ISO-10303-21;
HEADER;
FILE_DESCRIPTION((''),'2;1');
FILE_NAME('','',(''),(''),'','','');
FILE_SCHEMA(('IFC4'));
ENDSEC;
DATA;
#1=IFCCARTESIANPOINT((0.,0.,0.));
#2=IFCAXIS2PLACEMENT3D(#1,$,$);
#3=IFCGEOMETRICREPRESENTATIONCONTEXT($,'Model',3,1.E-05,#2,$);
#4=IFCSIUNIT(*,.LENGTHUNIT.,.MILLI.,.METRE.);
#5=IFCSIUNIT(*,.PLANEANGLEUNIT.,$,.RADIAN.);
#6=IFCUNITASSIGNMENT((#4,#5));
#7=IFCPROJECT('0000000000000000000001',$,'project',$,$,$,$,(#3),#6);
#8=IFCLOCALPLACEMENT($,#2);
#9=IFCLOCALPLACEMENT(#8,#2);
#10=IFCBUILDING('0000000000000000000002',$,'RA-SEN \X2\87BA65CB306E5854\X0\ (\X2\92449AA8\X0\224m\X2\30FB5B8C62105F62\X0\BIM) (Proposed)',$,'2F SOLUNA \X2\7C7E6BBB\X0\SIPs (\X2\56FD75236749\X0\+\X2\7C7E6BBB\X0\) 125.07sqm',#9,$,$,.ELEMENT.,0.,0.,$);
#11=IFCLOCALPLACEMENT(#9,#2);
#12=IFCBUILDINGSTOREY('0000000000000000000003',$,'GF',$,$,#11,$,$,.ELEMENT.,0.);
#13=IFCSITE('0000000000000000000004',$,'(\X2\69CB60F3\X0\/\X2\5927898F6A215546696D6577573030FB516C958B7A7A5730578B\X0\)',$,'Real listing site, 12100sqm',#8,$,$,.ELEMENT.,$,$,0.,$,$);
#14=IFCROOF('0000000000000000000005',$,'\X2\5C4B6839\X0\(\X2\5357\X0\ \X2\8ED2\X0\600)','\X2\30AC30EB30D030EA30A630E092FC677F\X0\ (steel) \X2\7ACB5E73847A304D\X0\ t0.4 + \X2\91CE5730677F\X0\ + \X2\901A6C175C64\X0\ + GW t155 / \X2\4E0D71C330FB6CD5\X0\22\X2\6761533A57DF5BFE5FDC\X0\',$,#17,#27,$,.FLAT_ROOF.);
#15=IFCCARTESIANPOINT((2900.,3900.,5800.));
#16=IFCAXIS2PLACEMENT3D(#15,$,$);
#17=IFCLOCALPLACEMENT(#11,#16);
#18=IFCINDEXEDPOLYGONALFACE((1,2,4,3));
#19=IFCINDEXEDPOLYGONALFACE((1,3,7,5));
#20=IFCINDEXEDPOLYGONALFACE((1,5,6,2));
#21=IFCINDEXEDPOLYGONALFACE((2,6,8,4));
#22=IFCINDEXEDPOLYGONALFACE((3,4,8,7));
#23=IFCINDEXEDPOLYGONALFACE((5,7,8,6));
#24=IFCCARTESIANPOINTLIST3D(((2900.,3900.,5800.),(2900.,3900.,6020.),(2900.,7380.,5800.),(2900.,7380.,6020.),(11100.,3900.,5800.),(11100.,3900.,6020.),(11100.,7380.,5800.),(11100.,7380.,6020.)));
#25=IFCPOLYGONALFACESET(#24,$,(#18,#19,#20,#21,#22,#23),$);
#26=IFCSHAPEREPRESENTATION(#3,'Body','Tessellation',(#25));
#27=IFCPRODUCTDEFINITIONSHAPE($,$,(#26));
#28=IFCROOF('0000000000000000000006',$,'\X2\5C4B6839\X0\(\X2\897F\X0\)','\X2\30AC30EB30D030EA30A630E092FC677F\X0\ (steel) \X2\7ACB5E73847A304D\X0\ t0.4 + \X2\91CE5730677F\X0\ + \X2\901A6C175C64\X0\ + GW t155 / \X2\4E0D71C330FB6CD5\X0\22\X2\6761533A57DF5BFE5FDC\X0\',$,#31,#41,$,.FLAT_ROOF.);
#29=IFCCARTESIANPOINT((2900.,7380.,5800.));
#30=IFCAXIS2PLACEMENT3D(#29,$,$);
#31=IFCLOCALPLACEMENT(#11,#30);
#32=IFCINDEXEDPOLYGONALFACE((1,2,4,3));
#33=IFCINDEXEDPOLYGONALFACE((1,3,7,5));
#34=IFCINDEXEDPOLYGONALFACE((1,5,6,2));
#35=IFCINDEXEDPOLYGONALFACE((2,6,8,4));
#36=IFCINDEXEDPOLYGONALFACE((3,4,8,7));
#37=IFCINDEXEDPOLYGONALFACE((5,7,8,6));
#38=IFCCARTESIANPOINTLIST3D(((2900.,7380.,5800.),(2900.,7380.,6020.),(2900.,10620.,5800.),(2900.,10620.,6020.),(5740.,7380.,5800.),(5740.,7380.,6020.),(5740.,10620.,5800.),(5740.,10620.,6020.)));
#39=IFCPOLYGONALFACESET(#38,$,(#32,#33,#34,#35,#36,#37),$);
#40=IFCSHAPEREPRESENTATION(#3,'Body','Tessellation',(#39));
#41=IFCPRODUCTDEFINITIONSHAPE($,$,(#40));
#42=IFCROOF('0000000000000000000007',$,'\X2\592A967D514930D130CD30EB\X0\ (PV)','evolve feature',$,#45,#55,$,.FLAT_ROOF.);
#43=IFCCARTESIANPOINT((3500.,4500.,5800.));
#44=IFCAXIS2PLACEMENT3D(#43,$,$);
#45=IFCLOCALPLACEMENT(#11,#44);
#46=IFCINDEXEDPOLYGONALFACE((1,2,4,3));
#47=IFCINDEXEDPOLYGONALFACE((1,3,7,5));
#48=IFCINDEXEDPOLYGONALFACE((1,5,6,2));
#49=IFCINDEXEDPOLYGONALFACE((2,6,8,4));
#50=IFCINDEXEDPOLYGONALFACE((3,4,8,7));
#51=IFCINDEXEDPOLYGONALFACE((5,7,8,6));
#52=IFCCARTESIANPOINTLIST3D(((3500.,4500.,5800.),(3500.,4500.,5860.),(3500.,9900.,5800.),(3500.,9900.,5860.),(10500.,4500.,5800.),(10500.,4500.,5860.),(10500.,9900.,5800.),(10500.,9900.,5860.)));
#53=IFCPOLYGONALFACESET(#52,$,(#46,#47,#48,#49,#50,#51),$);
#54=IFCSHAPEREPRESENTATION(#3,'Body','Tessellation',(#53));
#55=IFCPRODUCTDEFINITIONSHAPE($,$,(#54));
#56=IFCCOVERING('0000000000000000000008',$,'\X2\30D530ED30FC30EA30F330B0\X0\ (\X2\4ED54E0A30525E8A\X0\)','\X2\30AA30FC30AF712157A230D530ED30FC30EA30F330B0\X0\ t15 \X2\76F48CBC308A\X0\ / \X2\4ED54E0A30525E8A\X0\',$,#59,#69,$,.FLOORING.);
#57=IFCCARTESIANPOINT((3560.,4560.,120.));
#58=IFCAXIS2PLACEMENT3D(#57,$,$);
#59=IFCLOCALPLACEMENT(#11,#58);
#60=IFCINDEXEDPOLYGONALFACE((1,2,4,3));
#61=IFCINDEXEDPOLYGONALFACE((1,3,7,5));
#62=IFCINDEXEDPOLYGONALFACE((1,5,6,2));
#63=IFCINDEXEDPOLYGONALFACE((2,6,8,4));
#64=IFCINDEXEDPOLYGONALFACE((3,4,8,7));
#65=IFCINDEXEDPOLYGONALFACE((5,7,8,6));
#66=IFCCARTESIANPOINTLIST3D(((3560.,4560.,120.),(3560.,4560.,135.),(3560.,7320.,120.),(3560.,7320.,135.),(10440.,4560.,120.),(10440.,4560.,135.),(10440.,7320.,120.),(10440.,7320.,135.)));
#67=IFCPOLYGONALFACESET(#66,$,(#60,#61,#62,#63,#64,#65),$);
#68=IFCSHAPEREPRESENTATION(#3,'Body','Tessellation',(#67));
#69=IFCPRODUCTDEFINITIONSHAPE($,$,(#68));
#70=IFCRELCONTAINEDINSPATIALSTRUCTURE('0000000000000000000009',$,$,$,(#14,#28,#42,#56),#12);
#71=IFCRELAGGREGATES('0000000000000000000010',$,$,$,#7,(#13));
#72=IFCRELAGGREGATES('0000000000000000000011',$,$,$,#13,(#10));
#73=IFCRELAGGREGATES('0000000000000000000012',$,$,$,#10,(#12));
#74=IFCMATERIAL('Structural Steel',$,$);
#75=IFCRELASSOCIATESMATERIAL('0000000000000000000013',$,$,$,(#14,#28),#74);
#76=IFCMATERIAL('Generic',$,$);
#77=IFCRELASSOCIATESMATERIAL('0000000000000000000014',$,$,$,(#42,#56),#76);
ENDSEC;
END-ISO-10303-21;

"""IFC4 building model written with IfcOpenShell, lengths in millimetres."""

from ifc_helpers import new_model, si_unit, frame, frame_2d, origin, place, context, project, spatial, rectangle, extrude, material, element, save


model = new_model("IFC4")

# Units and contexts
model_context = context("Model", 3, precision=1e-05, world=origin())
ifc_project = project(units=[si_unit("LENGTHUNIT", "METRE", prefix="MILLI"), si_unit("PLANEANGLEUNIT", "RADIAN")], contexts=[model_context])

# Site, building, storey
site_placement = place(None, origin())
site = spatial("IfcSite", under=ifc_project, at=site_placement, Name="(構想/大規模商業敷地・公開空地型)", ObjectType="Real listing site, 12100sqm", CompositionType="ELEMENT", RefElevation=0.0)
building_placement = place(site_placement, origin())
building = spatial("IfcBuilding", under=site, at=building_placement, Name="RA-SEN 螺旋の塔 (鉄骨224m・完成形BIM) (Proposed)", ObjectType="2F SOLUNA 籾殻SIPs (国産杉+籾殻) 125.07sqm", CompositionType="ELEMENT", ElevationOfRefHeight=0.0, ElevationOfTerrain=0.0)
storey_placement = place(building_placement, origin())
storey = spatial("IfcBuildingStorey", under=building, at=storey_placement, Name="GF", CompositionType="ELEMENT", Elevation=0.0)

# Shared definitions
ifc_material_1 = material(Name="Generic")

# Roofs
ifc_material_2 = material(Name="Structural Steel")
roof_1_placement = place(storey_placement, frame((2900.0, 3900.0, 5800.0)))
element("IfcRoof", 1, at=roof_1_placement, inside=storey, material=ifc_material_2, Name="屋根(南 軒600)", Description="ガルバリウム鋼板 (steel) 立平葺き t0.4 + 野地板 + 通気層 + GW t155 / 不燃・法22条区域対応", PredefinedType="FLAT_ROOF", context=model_context, shape_type="SweptSolid", body=[
    extrude(rectangle(XDim=8200.0, YDim=3480.0, at=frame_2d((4100.0, 1740.0))), frame((2900.0, 3900.0, 5800.0)), (0.0, 0.0, 1.0), 220.0),
])
roof_2_placement = place(storey_placement, frame((2900.0, 7380.0, 5800.0)))
element("IfcRoof", 2, at=roof_2_placement, inside=storey, material=ifc_material_2, Name="屋根(西)", Description="ガルバリウム鋼板 (steel) 立平葺き t0.4 + 野地板 + 通気層 + GW t155 / 不燃・法22条区域対応", PredefinedType="FLAT_ROOF", context=model_context, shape_type="SweptSolid", body=[
    extrude(rectangle(XDim=2840.0, YDim=3240.0, at=frame_2d((1420.0, 1620.0))), frame((2900.0, 7380.0, 5800.0)), (0.0, 0.0, 1.0), 220.0),
])
roof_3_placement = place(storey_placement, frame((3500.0, 4500.0, 5800.0)))
element("IfcRoof", 3, at=roof_3_placement, inside=storey, material=ifc_material_1, Name="太陽光パネル (PV)", Description="evolve feature", PredefinedType="FLAT_ROOF", context=model_context, shape_type="SweptSolid", body=[
    extrude(rectangle(XDim=7000.0, YDim=5400.0, at=frame_2d((3500.0, 2700.0))), frame((3500.0, 4500.0, 5800.0)), (0.0, 0.0, 1.0), 60.0),
])

# Covering
covering_placement = place(storey_placement, frame((3560.0, 4560.0, 120.0)))
element("IfcCovering", 4, at=covering_placement, inside=storey, material=ifc_material_1, Name="フローリング (仕上げ床)", Description="オーク無垢フローリング t15 直貼り / 仕上げ床", PredefinedType="FLOORING", context=model_context, shape_type="SweptSolid", body=[
    extrude(rectangle(XDim=6880.0, YDim=2760.0, at=frame_2d((3440.0, 1380.0))), frame((3560.0, 4560.0, 120.0)), (0.0, 0.0, 1.0), 15.0),
])

save(model, "model.ifc")
